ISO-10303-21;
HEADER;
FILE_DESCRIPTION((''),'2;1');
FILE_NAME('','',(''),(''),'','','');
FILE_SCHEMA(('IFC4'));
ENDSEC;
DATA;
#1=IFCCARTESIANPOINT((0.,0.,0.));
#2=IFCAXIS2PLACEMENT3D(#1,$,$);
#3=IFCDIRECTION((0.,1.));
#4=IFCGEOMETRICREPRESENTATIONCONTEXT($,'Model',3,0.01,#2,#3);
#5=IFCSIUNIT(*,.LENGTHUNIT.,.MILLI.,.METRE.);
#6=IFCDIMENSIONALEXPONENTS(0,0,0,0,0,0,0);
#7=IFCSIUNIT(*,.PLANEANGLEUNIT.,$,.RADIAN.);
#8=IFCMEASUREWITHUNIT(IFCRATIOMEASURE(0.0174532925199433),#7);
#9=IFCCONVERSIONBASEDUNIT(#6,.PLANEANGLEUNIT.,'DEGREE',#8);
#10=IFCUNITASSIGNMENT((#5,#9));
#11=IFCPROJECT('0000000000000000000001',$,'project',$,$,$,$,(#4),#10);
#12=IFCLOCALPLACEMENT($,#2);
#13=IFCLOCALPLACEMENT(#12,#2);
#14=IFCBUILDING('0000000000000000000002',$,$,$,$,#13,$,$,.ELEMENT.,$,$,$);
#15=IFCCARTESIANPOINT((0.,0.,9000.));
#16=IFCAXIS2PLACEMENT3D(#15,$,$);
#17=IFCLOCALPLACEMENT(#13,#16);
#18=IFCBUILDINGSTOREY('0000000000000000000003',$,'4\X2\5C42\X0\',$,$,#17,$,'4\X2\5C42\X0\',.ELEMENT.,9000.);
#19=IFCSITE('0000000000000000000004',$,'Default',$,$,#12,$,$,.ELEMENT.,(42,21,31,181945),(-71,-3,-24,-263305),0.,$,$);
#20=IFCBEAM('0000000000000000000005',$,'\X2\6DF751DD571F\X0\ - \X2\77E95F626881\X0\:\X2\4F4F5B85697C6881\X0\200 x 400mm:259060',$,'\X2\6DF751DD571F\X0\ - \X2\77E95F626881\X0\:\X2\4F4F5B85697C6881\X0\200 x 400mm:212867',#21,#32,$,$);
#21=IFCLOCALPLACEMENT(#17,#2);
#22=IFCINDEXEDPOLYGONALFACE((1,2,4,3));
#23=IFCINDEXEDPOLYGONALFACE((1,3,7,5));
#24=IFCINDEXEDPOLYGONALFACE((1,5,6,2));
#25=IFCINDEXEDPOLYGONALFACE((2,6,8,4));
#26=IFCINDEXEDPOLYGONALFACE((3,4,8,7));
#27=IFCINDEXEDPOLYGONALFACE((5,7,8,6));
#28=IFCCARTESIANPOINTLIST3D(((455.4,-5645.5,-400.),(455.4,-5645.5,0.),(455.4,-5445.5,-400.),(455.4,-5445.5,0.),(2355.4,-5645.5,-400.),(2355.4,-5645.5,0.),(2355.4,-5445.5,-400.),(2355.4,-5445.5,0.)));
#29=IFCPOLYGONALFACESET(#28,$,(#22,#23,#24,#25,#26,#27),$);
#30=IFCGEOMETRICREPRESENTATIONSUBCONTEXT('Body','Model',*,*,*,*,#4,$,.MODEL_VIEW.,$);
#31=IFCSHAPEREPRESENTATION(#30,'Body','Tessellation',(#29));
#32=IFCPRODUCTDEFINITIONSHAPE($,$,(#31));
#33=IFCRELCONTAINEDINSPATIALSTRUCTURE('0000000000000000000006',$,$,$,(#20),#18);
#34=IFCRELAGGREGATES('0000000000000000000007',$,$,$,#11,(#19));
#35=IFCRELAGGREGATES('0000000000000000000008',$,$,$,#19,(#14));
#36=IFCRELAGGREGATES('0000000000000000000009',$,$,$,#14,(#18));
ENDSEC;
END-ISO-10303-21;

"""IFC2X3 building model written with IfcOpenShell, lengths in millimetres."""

from ifc_helpers import new_model, entity, si_unit, converted_unit, direction, frame, frame_2d, origin, place, context, subcontext, project, spatial, rectangle, extrude, element, save


model = new_model("IFC2X3")

# Units and contexts
model_context = context("Model", 3, precision=0.01, world=origin(), true_north=direction((0.0, 1.0)))
body_context = subcontext(model_context, "Body", "Model", "MODEL_VIEW")
ifc_project = project(units=[si_unit("LENGTHUNIT", "METRE", prefix="MILLI"), converted_unit("PLANEANGLEUNIT", "DEGREE", entity("IfcRatioMeasure", 0.0174532925199433), si_unit("PLANEANGLEUNIT", "RADIAN"), dimensions=[0, 0, 0, 0, 0, 0, 0])], contexts=[model_context])

# Site, building, storey
site_placement = place(None, origin())
site = spatial("IfcSite", under=ifc_project, at=site_placement, Name="Default", CompositionType="ELEMENT", RefLatitude=(42, 21, 31, 181945), RefLongitude=(-71, -3, -24, -263305), RefElevation=0.0)
building_placement = place(site_placement, origin())
building = spatial("IfcBuilding", under=site, at=building_placement, CompositionType="ELEMENT")
storey_placement = place(building_placement, frame((0.0, 0.0, 9000.0)))
storey = spatial("IfcBuildingStorey", under=building, at=storey_placement, Name="4层", LongName="4层", CompositionType="ELEMENT", Elevation=9000.0)

# Beam
beam_placement = place(storey_placement, frame((2455.4, -5545.5, 0.0), z_axis=(0.0, 0.0, 1.0), x_axis=(-1.0, 0.0, 0.0)))
element("IfcBeam", 1, at=beam_placement, inside=storey, Name="混凝土 - 矩形梁:住宅楼梁200 x 400mm:259060", ObjectType="混凝土 - 矩形梁:住宅楼梁200 x 400mm:212867", context=body_context, shape_type="SweptSolid", body=[
    extrude(rectangle(XDim=400.0, YDim=200.0, at=frame_2d((0.0, 0.0), x_axis=(1.0, 0.0))), frame((100.0, 0.0, -200.0), z_axis=(1.0, 0.0, 0.0), x_axis=(0.0, 0.0, -1.0)), (0.0, 0.0, 1.0), 1900.0),
])

save(model, "model.ifc")
